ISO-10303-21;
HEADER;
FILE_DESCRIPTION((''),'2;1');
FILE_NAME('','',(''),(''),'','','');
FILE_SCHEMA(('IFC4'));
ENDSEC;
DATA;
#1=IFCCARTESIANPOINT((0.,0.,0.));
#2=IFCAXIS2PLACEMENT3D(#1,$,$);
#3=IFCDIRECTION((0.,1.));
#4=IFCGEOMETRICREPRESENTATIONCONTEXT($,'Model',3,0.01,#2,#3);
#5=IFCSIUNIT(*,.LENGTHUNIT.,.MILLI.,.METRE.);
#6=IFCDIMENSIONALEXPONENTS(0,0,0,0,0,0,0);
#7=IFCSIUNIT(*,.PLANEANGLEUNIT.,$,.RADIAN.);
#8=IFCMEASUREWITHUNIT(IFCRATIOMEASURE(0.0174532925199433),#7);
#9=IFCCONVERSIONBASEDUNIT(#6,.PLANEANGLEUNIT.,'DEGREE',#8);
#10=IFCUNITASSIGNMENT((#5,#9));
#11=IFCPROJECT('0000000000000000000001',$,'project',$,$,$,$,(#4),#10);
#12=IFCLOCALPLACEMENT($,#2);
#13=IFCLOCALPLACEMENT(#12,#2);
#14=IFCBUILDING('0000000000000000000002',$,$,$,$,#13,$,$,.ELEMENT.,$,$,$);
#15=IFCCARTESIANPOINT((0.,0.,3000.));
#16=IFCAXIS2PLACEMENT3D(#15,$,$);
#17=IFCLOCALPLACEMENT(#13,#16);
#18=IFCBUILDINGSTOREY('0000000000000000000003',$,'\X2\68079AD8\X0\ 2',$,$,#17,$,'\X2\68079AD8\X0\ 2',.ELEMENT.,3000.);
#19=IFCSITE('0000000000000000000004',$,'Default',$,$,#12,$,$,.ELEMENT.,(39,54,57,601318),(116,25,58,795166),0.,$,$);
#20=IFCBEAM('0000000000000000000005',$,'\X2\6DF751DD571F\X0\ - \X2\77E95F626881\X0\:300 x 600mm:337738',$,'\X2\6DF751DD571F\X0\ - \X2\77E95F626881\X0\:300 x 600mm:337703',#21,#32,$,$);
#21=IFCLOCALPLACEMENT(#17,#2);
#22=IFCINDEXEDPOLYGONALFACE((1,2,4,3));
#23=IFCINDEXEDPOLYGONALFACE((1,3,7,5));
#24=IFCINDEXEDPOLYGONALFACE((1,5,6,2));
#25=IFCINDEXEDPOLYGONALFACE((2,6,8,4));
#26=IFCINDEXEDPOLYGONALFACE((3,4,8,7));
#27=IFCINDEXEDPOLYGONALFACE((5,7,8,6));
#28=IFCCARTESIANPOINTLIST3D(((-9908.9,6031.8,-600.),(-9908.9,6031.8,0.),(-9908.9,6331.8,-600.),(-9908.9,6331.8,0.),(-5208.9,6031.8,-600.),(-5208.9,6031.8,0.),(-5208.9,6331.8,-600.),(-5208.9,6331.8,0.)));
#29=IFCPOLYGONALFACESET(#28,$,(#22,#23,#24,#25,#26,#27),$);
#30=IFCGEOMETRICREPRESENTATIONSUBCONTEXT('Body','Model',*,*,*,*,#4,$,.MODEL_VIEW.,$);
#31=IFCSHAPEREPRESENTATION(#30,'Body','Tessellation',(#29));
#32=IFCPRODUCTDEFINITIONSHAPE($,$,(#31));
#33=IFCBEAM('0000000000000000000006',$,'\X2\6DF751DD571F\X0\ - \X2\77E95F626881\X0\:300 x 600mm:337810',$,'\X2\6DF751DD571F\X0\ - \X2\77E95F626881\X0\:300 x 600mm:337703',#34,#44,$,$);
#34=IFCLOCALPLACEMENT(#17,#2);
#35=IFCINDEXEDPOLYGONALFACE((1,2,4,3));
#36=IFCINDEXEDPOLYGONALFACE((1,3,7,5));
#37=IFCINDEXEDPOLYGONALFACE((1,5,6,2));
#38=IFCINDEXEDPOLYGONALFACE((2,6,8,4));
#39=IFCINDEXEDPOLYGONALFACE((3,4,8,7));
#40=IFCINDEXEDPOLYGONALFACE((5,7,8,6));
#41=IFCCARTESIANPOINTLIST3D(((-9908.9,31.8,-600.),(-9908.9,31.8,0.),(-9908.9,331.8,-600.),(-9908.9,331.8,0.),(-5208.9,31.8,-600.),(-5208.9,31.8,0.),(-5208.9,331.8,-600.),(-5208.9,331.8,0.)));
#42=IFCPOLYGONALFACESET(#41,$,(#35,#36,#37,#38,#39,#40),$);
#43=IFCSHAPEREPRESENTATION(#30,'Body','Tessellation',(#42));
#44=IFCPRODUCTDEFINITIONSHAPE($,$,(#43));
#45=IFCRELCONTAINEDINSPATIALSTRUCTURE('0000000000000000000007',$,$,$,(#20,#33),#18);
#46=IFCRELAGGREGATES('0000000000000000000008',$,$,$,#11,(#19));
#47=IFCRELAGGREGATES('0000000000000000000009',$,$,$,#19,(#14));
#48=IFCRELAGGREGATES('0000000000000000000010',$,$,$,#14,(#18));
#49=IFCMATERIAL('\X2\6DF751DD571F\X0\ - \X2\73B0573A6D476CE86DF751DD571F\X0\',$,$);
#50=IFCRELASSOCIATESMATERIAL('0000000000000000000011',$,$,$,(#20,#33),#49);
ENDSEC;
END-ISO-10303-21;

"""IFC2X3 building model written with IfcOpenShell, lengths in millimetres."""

from ifc_helpers import new_model, entity, si_unit, converted_unit, direction, frame, frame_2d, origin, place, context, subcontext, project, spatial, rectangle, extrude, material, element, save


model = new_model("IFC2X3")

# Units and contexts
model_context = context("Model", 3, precision=0.01, world=origin(), true_north=direction((0.0, 1.0)))
body_context = subcontext(model_context, "Body", "Model", "MODEL_VIEW")
ifc_project = project(units=[si_unit("LENGTHUNIT", "METRE", prefix="MILLI"), converted_unit("PLANEANGLEUNIT", "DEGREE", entity("IfcRatioMeasure", 0.0174532925199433), si_unit("PLANEANGLEUNIT", "RADIAN"), dimensions=[0, 0, 0, 0, 0, 0, 0])], contexts=[model_context])

# Site, building, storey
site_placement = place(None, origin())
site = spatial("IfcSite", under=ifc_project, at=site_placement, Name="Default", CompositionType="ELEMENT", RefLatitude=(39, 54, 57, 601318), RefLongitude=(116, 25, 58, 795166), RefElevation=0.0)
building_placement = place(site_placement, origin())
building = spatial("IfcBuilding", under=site, at=building_placement, CompositionType="ELEMENT")
storey_placement = place(building_placement, frame((0.0, 0.0, 3000.0)))
storey = spatial("IfcBuildingStorey", under=building, at=storey_placement, Name="标高 2", LongName="标高 2", CompositionType="ELEMENT", Elevation=3000.0)

# Beams
ifc_material = material(Name="混凝土 - 现场浇注混凝土")
beam_1_placement = place(storey_placement, frame((-10058.9, 6181.8, 0.0)))
element("IfcBeam", 1, at=beam_1_placement, inside=storey, material=ifc_material, Name="混凝土 - 矩形梁:300 x 600mm:337738", ObjectType="混凝土 - 矩形梁:300 x 600mm:337703", context=body_context, shape_type="SweptSolid", body=[
    extrude(rectangle(XDim=600.0, YDim=300.0, at=frame_2d((0.0, 0.0), x_axis=(1.0, 0.0))), frame((150.0, 0.0, -300.0), z_axis=(1.0, 0.0, 0.0), x_axis=(0.0, 0.0, -1.0)), (0.0, 0.0, 1.0), 4700.0),
])
beam_2_placement = place(storey_placement, frame((-10058.9, 181.8, 0.0)))
element("IfcBeam", 2, at=beam_2_placement, inside=storey, material=ifc_material, Name="混凝土 - 矩形梁:300 x 600mm:337810", ObjectType="混凝土 - 矩形梁:300 x 600mm:337703", context=body_context, shape_type="SweptSolid", body=[
    extrude(rectangle(XDim=600.0, YDim=300.0, at=frame_2d((0.0, 0.0), x_axis=(1.0, 0.0))), frame((150.0, 0.0, -300.0), z_axis=(1.0, 0.0, 0.0), x_axis=(0.0, 0.0, -1.0)), (0.0, 0.0, 1.0), 4700.0),
])

save(model, "model.ifc")
